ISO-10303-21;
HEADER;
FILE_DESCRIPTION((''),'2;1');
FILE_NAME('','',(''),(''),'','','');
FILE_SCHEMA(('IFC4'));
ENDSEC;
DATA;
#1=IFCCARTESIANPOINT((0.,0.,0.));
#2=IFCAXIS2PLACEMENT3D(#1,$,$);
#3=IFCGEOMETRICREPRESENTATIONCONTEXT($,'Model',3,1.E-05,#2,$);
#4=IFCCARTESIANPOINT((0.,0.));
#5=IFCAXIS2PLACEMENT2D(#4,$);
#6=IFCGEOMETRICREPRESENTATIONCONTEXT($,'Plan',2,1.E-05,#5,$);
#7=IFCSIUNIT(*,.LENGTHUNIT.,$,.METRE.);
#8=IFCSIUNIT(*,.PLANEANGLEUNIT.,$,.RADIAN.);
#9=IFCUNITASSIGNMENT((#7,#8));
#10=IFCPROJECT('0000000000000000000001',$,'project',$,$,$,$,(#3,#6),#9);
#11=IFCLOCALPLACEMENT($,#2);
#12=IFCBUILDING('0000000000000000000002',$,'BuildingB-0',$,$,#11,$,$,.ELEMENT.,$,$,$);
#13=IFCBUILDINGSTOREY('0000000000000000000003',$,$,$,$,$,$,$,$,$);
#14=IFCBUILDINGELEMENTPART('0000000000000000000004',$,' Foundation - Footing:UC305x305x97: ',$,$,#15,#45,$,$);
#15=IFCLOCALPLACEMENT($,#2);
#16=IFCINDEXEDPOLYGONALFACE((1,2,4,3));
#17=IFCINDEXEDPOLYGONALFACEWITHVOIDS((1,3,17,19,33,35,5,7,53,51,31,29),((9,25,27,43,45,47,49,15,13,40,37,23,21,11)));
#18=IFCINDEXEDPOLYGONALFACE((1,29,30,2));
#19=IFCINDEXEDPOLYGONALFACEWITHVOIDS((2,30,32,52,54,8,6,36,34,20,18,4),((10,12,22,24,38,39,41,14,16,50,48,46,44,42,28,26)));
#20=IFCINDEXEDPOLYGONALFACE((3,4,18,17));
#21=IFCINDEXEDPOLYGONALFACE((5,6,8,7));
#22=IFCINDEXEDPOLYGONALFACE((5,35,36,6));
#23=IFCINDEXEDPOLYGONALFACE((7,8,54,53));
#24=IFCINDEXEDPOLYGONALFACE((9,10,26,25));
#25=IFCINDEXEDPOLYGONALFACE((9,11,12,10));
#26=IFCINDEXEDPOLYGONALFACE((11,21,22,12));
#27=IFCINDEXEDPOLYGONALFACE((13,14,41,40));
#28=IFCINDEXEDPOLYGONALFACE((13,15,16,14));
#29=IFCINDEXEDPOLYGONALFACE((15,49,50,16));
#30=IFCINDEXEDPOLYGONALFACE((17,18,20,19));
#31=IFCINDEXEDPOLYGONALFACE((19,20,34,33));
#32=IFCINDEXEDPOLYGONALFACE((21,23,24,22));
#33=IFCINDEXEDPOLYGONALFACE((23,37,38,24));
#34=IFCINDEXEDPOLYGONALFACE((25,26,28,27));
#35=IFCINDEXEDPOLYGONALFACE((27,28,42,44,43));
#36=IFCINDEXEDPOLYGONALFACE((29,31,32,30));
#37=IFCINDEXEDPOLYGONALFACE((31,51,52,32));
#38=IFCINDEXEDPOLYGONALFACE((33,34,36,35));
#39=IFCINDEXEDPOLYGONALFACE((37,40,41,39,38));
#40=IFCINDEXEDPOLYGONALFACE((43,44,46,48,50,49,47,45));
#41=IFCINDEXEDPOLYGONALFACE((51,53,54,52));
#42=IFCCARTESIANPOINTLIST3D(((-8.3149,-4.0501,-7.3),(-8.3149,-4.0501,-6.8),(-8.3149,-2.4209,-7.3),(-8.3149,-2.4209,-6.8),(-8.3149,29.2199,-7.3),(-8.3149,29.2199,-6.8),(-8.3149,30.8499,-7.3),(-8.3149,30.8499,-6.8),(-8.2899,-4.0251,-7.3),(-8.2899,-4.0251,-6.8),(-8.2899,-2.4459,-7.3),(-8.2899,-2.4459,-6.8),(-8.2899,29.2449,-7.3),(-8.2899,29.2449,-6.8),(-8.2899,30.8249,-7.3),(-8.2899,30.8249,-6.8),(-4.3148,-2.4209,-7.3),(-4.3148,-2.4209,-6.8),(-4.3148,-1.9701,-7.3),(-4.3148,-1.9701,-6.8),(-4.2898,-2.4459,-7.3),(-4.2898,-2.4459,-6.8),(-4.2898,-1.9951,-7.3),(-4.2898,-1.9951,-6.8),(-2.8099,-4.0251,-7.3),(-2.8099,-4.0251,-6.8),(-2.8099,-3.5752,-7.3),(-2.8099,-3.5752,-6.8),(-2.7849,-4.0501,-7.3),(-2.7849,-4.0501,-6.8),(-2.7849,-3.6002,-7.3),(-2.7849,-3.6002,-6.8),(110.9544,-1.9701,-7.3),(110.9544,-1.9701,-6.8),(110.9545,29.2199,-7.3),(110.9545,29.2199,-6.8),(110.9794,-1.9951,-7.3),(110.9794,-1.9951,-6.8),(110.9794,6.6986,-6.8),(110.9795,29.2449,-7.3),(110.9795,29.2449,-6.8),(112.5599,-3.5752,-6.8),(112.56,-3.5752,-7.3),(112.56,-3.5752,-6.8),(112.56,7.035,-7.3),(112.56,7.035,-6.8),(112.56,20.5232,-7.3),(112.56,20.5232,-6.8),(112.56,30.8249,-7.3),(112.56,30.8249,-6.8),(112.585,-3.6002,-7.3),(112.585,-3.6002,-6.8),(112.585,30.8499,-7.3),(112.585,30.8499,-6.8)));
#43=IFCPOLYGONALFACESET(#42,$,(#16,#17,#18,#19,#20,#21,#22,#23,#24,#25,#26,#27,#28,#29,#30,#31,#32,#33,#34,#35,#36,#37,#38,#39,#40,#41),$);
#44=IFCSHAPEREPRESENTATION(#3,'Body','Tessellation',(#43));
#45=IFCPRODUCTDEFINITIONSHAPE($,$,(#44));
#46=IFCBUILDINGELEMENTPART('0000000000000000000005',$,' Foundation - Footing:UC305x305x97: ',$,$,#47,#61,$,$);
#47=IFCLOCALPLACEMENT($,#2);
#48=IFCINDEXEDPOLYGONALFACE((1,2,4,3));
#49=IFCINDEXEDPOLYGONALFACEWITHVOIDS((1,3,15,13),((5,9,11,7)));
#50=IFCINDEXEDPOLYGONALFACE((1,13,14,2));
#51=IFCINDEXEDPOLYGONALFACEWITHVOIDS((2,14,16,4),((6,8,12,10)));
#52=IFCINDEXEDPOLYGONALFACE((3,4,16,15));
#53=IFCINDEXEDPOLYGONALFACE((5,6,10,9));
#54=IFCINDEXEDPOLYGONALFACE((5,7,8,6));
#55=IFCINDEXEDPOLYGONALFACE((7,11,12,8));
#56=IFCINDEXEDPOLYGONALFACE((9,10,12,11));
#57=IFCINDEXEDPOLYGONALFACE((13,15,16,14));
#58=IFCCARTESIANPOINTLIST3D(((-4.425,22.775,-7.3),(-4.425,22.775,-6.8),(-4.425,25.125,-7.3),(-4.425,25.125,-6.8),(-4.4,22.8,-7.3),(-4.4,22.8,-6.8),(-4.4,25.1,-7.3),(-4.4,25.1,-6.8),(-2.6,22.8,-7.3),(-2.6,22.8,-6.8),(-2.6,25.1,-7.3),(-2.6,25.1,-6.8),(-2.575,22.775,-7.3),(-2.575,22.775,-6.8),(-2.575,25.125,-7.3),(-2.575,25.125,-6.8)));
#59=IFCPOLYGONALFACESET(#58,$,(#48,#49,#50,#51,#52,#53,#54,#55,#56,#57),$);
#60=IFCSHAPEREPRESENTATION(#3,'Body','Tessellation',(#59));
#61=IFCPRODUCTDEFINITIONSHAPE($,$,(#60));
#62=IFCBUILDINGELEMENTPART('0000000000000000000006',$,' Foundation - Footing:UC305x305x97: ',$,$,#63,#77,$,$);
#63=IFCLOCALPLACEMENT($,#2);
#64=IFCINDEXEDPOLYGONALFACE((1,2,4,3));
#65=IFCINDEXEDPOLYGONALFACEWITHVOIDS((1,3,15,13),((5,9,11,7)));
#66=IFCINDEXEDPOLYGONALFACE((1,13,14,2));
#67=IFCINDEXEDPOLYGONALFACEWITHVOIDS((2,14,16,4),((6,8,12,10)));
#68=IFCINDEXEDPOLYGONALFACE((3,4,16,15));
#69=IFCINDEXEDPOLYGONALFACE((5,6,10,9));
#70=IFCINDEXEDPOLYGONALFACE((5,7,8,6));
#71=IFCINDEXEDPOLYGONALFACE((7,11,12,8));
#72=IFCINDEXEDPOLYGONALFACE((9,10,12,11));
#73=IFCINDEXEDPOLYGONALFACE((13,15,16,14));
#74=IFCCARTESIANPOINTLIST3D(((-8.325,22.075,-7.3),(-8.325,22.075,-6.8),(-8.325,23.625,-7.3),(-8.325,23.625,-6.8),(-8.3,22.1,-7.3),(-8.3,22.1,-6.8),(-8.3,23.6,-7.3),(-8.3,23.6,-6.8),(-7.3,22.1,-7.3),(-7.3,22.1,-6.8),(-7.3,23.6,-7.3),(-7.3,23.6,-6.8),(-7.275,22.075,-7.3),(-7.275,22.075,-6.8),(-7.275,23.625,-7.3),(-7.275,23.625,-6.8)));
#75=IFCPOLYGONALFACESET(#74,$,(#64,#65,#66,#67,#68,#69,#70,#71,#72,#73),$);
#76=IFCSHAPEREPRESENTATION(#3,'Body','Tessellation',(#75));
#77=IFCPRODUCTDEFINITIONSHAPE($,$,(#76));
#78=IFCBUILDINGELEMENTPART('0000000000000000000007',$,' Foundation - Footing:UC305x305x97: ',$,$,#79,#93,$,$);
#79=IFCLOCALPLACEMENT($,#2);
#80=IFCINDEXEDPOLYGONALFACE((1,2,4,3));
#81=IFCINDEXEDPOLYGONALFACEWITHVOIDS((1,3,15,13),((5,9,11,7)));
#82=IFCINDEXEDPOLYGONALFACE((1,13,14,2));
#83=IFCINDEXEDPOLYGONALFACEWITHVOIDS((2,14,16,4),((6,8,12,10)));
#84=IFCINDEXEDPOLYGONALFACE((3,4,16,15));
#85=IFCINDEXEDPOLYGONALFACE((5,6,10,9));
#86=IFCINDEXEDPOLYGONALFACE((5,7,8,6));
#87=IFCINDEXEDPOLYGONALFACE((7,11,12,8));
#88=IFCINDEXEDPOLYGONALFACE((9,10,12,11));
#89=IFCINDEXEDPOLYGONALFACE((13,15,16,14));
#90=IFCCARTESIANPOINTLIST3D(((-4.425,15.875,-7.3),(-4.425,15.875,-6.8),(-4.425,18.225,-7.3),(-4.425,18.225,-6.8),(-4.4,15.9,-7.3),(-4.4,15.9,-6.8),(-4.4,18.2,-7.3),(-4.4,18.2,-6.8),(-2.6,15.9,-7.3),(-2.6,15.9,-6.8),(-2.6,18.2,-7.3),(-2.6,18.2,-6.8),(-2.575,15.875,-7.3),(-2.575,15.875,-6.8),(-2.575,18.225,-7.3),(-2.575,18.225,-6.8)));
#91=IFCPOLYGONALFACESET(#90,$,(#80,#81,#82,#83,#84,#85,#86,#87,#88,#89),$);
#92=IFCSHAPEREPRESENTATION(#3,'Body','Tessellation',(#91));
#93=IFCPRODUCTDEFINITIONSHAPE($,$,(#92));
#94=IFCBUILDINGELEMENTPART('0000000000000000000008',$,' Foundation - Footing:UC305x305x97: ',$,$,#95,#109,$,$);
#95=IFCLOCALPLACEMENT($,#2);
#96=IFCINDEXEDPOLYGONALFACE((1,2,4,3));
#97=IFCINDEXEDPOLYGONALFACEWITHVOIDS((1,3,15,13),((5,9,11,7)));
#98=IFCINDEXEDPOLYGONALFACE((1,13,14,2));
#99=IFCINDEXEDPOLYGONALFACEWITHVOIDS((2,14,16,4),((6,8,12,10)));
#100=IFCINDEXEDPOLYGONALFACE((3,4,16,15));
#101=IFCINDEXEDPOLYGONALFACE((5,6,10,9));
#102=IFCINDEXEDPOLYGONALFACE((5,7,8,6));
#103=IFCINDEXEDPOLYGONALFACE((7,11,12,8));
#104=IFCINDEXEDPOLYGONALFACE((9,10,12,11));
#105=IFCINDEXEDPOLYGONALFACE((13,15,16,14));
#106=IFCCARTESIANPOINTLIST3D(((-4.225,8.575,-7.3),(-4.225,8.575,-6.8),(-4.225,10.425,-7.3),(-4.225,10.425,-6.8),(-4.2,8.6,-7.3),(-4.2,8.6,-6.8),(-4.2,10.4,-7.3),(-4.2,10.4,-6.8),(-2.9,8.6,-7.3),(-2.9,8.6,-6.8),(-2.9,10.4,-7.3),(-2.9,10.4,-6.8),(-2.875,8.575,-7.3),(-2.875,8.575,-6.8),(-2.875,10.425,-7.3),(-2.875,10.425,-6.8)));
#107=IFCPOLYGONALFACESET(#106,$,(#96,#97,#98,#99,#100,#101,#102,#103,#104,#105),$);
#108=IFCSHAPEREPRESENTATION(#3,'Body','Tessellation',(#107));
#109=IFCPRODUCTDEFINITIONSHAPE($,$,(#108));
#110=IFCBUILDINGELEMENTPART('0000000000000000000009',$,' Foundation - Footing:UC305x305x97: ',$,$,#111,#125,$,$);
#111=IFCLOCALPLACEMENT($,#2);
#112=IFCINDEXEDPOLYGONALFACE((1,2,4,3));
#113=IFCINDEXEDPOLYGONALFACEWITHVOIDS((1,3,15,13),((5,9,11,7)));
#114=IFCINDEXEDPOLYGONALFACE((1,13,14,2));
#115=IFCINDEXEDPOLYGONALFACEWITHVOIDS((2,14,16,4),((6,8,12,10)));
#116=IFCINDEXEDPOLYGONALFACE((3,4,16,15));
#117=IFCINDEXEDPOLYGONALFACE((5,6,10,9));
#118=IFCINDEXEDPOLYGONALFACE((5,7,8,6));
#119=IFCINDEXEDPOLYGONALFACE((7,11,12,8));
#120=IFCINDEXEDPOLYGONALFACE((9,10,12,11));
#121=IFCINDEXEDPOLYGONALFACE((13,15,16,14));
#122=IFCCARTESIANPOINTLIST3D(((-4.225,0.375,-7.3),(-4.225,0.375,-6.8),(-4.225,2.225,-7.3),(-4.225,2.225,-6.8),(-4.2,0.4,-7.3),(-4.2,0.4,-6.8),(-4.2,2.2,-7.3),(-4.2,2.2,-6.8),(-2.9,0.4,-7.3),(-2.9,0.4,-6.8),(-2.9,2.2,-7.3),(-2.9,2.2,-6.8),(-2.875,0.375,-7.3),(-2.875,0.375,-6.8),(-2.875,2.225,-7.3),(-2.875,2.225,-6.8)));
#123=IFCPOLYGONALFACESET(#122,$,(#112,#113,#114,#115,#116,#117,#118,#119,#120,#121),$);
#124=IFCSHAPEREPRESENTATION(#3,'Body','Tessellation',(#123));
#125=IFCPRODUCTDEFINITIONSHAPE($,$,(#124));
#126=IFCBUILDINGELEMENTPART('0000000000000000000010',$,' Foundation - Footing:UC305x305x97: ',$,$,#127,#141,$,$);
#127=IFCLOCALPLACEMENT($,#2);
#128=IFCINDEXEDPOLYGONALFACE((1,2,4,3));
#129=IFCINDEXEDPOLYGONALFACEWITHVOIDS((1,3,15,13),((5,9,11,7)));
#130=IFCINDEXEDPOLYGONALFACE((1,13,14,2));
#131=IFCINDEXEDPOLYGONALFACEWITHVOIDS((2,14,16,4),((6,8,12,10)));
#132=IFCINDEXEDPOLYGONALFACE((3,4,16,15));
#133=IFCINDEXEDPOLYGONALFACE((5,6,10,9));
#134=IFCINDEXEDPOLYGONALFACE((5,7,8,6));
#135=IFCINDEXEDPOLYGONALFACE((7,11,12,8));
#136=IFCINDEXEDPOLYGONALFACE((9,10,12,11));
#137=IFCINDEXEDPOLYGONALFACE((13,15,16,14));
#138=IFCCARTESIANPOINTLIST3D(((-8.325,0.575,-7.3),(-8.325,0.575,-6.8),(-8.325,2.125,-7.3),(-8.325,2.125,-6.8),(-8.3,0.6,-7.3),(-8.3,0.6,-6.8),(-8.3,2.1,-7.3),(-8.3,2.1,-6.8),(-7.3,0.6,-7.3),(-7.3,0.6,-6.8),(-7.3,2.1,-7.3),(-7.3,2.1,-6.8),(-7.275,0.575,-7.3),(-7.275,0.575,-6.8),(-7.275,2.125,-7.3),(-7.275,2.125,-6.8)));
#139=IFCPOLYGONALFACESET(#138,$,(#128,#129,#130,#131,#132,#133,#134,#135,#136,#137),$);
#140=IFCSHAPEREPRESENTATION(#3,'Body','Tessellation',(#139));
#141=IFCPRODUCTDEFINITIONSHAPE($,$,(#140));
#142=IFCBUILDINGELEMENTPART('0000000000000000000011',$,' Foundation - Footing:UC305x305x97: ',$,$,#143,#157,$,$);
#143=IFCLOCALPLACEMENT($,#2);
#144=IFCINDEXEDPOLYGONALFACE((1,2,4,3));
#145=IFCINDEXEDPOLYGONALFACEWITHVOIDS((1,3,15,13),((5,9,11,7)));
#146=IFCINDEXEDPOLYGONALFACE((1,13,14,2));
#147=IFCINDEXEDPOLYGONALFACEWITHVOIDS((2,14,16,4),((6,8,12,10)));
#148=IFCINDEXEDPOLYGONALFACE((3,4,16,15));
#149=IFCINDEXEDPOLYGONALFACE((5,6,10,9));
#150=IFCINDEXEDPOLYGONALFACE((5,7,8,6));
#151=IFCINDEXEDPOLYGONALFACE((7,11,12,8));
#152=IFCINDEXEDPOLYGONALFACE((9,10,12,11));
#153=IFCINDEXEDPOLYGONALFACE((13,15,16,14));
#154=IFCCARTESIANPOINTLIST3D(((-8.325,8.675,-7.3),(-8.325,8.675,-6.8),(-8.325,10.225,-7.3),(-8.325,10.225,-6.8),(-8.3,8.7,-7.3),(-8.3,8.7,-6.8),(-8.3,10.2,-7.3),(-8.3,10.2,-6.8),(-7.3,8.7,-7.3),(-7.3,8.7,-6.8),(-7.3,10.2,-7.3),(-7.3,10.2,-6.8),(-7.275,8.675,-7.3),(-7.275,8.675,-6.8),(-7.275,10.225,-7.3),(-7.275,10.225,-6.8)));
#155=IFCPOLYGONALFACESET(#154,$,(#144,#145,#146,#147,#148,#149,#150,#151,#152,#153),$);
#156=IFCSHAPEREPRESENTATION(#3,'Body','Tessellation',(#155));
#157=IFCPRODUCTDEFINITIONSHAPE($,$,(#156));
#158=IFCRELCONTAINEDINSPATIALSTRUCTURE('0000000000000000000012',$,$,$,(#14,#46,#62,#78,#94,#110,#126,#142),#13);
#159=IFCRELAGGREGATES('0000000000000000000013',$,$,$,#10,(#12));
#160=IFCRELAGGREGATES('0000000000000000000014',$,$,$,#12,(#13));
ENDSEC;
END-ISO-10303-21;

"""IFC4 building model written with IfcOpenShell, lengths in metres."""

from ifc_helpers import new_model, si_unit, origin, origin_2d, place, context, project, spatial, polyline, outline, extrude, element, save


model = new_model("IFC4")

# Units and contexts
model_context = context("Model", 3, precision=1e-05, world=origin())
plan_context = context("Plan", 2, precision=1e-05, world=origin_2d())
ifc_project = project(units=[si_unit("LENGTHUNIT", "METRE"), si_unit("PLANEANGLEUNIT", "RADIAN")], contexts=[model_context, plan_context])

# Building, storey
building_placement = place(None, origin())
building = spatial("IfcBuilding", under=ifc_project, at=building_placement, Name="BuildingB-0", CompositionType="ELEMENT")
storey = spatial("IfcBuildingStorey", under=building)

# Building element parts, openings
building_element_part_1 = element("IfcBuildingElementPart", 1, inside=storey, Name=" Foundation - Footing:UC305x305x97: ", context=model_context, shape_type="SweptSolid", body=[
    extrude(outline(polyline([(-8.3149, 30.8499, -7.3), (112.585, 30.8499, -7.3), (112.585, 20.5232, -7.3), (112.585, 7.035, -7.3), (112.585, -3.6002, -7.3), (-2.7849, -3.6002, -7.3), (-2.7849, -4.0501, -7.3), (-8.3149, -4.0501, -7.3), (-8.3149, -2.4209, -7.3), (-4.3148, -2.4209, -7.3), (-4.3148, -1.9701, -7.3), (110.9544, -1.9701, -7.3), (110.9544, -0.5214, -7.3), (110.9544, 6.6986, -7.3), (110.9545, 29.2199, -7.3), (-8.3149, 29.2199, -7.3), (-8.3149, 30.8499, -7.3)])), None, (0.0, 0.0, 1.0), 0.5),
])
element("IfcOpeningElement", 2, inside=storey, cuts=building_element_part_1, context=model_context, shape_type="SweptSolid", body=[
    extrude(outline(polyline([(-8.2899, 30.8249, -7.3), (112.56, 30.8249, -7.3), (112.56, 20.5232, -7.3), (112.56, 7.035, -7.3), (112.56, -3.5752, -7.3), (-2.8099, -3.5752, -7.3), (-2.8099, -4.0251, -7.3), (-8.2899, -4.0251, -7.3), (-8.2899, -2.4459, -7.3), (-4.2898, -2.4459, -7.3), (-4.2898, -1.9951, -7.3), (110.9794, -1.9951, -7.3), (110.9794, -0.5214, -7.3), (110.9794, 6.6986, -7.3), (110.9795, 29.2449, -7.3), (-8.2899, 29.2449, -7.3), (-8.2899, 30.8249, -7.3)])), None, (0.0, 0.0, 1.0), 0.5),
])
building_element_part_2 = element("IfcBuildingElementPart", 3, inside=storey, Name=" Foundation - Footing:UC305x305x97: ", context=model_context, shape_type="SweptSolid", body=[
    extrude(outline(polyline([(-4.425, 25.125, -7.3), (-2.575, 25.125, -7.3), (-2.575, 22.775, -7.3), (-4.425, 22.775, -7.3), (-4.425, 25.125, -7.3)])), None, (0.0, 0.0, 1.0), 0.5),
])
element("IfcOpeningElement", 4, inside=storey, cuts=building_element_part_2, context=model_context, shape_type="SweptSolid", body=[
    extrude(outline(polyline([(-4.4, 25.1, -7.3), (-2.6, 25.1, -7.3), (-2.6, 22.8, -7.3), (-4.4, 22.8, -7.3), (-4.4, 25.1, -7.3)])), None, (0.0, 0.0, 1.0), 0.5),
])
building_element_part_3 = element("IfcBuildingElementPart", 5, inside=storey, Name=" Foundation - Footing:UC305x305x97: ", context=model_context, shape_type="SweptSolid", body=[
    extrude(outline(polyline([(-7.275, 23.625, -7.3), (-8.325, 23.625, -7.3), (-8.325, 22.075, -7.3), (-7.275, 22.075, -7.3), (-7.275, 23.625, -7.3)])), None, (0.0, 0.0, 1.0), 0.5),
])
element("IfcOpeningElement", 6, inside=storey, cuts=building_element_part_3, context=model_context, shape_type="SweptSolid", body=[
    extrude(outline(polyline([(-7.3, 23.6, -7.3), (-8.3, 23.6, -7.3), (-8.3, 22.1, -7.3), (-7.3, 22.1, -7.3), (-7.3, 23.6, -7.3)])), None, (0.0, 0.0, 1.0), 0.5),
])
building_element_part_4 = element("IfcBuildingElementPart", 7, inside=storey, Name=" Foundation - Footing:UC305x305x97: ", context=model_context, shape_type="SweptSolid", body=[
    extrude(outline(polyline([(-2.575, 18.225, -7.3), (-4.425, 18.225, -7.3), (-4.425, 15.875, -7.3), (-2.575, 15.875, -7.3), (-2.575, 18.225, -7.3)])), None, (0.0, 0.0, 1.0), 0.5),
])
element("IfcOpeningElement", 8, inside=storey, cuts=building_element_part_4, context=model_context, shape_type="SweptSolid", body=[
    extrude(outline(polyline([(-2.6, 18.2, -7.3), (-4.4, 18.2, -7.3), (-4.4, 15.9, -7.3), (-2.6, 15.9, -7.3), (-2.6, 18.2, -7.3)])), None, (0.0, 0.0, 1.0), 0.5),
])
building_element_part_5 = element("IfcBuildingElementPart", 9, inside=storey, Name=" Foundation - Footing:UC305x305x97: ", context=model_context, shape_type="SweptSolid", body=[
    extrude(outline(polyline([(-2.875, 10.425, -7.3), (-4.225, 10.425, -7.3), (-4.225, 8.575, -7.3), (-2.875, 8.575, -7.3), (-2.875, 10.425, -7.3)])), None, (0.0, 0.0, 1.0), 0.5),
])
element("IfcOpeningElement", 10, inside=storey, cuts=building_element_part_5, context=model_context, shape_type="SweptSolid", body=[
    extrude(outline(polyline([(-2.9, 10.4, -7.3), (-4.2, 10.4, -7.3), (-4.2, 8.6, -7.3), (-2.9, 8.6, -7.3), (-2.9, 10.4, -7.3)])), None, (0.0, 0.0, 1.0), 0.5),
])
building_element_part_6 = element("IfcBuildingElementPart", 11, inside=storey, Name=" Foundation - Footing:UC305x305x97: ", context=model_context, shape_type="SweptSolid", body=[
    extrude(outline(polyline([(-2.875, 2.225, -7.3), (-4.225, 2.225, -7.3), (-4.225, 0.375, -7.3), (-2.875, 0.375, -7.3), (-2.875, 2.225, -7.3)])), None, (0.0, 0.0, 1.0), 0.5),
])
element("IfcOpeningElement", 12, inside=storey, cuts=building_element_part_6, context=model_context, shape_type="SweptSolid", body=[
    extrude(outline(polyline([(-2.9, 2.2, -7.3), (-4.2, 2.2, -7.3), (-4.2, 0.4, -7.3), (-2.9, 0.4, -7.3), (-2.9, 2.2, -7.3)])), None, (0.0, 0.0, 1.0), 0.5),
])
building_element_part_7 = element("IfcBuildingElementPart", 13, inside=storey, Name=" Foundation - Footing:UC305x305x97: ", context=model_context, shape_type="SweptSolid", body=[
    extrude(outline(polyline([(-7.275, 2.125, -7.3), (-8.325, 2.125, -7.3), (-8.325, 0.575, -7.3), (-7.275, 0.575, -7.3), (-7.275, 2.125, -7.3)])), None, (0.0, 0.0, 1.0), 0.5),
])
element("IfcOpeningElement", 14, inside=storey, cuts=building_element_part_7, context=model_context, shape_type="SweptSolid", body=[
    extrude(outline(polyline([(-7.3, 2.1, -7.3), (-8.3, 2.1, -7.3), (-8.3, 0.6, -7.3), (-7.3, 0.6, -7.3), (-7.3, 2.1, -7.3)])), None, (0.0, 0.0, 1.0), 0.5),
])
building_element_part_8 = element("IfcBuildingElementPart", 15, inside=storey, Name=" Foundation - Footing:UC305x305x97: ", context=model_context, shape_type="SweptSolid", body=[
    extrude(outline(polyline([(-7.275, 10.225, -7.3), (-8.325, 10.225, -7.3), (-8.325, 8.675, -7.3), (-7.275, 8.675, -7.3), (-7.275, 10.225, -7.3)])), None, (0.0, 0.0, 1.0), 0.5),
])
element("IfcOpeningElement", 16, inside=storey, cuts=building_element_part_8, context=model_context, shape_type="SweptSolid", body=[
    extrude(outline(polyline([(-7.3, 10.2, -7.3), (-8.3, 10.2, -7.3), (-8.3, 8.7, -7.3), (-7.3, 8.7, -7.3), (-7.3, 10.2, -7.3)])), None, (0.0, 0.0, 1.0), 0.5),
])

save(model, "model.ifc")
